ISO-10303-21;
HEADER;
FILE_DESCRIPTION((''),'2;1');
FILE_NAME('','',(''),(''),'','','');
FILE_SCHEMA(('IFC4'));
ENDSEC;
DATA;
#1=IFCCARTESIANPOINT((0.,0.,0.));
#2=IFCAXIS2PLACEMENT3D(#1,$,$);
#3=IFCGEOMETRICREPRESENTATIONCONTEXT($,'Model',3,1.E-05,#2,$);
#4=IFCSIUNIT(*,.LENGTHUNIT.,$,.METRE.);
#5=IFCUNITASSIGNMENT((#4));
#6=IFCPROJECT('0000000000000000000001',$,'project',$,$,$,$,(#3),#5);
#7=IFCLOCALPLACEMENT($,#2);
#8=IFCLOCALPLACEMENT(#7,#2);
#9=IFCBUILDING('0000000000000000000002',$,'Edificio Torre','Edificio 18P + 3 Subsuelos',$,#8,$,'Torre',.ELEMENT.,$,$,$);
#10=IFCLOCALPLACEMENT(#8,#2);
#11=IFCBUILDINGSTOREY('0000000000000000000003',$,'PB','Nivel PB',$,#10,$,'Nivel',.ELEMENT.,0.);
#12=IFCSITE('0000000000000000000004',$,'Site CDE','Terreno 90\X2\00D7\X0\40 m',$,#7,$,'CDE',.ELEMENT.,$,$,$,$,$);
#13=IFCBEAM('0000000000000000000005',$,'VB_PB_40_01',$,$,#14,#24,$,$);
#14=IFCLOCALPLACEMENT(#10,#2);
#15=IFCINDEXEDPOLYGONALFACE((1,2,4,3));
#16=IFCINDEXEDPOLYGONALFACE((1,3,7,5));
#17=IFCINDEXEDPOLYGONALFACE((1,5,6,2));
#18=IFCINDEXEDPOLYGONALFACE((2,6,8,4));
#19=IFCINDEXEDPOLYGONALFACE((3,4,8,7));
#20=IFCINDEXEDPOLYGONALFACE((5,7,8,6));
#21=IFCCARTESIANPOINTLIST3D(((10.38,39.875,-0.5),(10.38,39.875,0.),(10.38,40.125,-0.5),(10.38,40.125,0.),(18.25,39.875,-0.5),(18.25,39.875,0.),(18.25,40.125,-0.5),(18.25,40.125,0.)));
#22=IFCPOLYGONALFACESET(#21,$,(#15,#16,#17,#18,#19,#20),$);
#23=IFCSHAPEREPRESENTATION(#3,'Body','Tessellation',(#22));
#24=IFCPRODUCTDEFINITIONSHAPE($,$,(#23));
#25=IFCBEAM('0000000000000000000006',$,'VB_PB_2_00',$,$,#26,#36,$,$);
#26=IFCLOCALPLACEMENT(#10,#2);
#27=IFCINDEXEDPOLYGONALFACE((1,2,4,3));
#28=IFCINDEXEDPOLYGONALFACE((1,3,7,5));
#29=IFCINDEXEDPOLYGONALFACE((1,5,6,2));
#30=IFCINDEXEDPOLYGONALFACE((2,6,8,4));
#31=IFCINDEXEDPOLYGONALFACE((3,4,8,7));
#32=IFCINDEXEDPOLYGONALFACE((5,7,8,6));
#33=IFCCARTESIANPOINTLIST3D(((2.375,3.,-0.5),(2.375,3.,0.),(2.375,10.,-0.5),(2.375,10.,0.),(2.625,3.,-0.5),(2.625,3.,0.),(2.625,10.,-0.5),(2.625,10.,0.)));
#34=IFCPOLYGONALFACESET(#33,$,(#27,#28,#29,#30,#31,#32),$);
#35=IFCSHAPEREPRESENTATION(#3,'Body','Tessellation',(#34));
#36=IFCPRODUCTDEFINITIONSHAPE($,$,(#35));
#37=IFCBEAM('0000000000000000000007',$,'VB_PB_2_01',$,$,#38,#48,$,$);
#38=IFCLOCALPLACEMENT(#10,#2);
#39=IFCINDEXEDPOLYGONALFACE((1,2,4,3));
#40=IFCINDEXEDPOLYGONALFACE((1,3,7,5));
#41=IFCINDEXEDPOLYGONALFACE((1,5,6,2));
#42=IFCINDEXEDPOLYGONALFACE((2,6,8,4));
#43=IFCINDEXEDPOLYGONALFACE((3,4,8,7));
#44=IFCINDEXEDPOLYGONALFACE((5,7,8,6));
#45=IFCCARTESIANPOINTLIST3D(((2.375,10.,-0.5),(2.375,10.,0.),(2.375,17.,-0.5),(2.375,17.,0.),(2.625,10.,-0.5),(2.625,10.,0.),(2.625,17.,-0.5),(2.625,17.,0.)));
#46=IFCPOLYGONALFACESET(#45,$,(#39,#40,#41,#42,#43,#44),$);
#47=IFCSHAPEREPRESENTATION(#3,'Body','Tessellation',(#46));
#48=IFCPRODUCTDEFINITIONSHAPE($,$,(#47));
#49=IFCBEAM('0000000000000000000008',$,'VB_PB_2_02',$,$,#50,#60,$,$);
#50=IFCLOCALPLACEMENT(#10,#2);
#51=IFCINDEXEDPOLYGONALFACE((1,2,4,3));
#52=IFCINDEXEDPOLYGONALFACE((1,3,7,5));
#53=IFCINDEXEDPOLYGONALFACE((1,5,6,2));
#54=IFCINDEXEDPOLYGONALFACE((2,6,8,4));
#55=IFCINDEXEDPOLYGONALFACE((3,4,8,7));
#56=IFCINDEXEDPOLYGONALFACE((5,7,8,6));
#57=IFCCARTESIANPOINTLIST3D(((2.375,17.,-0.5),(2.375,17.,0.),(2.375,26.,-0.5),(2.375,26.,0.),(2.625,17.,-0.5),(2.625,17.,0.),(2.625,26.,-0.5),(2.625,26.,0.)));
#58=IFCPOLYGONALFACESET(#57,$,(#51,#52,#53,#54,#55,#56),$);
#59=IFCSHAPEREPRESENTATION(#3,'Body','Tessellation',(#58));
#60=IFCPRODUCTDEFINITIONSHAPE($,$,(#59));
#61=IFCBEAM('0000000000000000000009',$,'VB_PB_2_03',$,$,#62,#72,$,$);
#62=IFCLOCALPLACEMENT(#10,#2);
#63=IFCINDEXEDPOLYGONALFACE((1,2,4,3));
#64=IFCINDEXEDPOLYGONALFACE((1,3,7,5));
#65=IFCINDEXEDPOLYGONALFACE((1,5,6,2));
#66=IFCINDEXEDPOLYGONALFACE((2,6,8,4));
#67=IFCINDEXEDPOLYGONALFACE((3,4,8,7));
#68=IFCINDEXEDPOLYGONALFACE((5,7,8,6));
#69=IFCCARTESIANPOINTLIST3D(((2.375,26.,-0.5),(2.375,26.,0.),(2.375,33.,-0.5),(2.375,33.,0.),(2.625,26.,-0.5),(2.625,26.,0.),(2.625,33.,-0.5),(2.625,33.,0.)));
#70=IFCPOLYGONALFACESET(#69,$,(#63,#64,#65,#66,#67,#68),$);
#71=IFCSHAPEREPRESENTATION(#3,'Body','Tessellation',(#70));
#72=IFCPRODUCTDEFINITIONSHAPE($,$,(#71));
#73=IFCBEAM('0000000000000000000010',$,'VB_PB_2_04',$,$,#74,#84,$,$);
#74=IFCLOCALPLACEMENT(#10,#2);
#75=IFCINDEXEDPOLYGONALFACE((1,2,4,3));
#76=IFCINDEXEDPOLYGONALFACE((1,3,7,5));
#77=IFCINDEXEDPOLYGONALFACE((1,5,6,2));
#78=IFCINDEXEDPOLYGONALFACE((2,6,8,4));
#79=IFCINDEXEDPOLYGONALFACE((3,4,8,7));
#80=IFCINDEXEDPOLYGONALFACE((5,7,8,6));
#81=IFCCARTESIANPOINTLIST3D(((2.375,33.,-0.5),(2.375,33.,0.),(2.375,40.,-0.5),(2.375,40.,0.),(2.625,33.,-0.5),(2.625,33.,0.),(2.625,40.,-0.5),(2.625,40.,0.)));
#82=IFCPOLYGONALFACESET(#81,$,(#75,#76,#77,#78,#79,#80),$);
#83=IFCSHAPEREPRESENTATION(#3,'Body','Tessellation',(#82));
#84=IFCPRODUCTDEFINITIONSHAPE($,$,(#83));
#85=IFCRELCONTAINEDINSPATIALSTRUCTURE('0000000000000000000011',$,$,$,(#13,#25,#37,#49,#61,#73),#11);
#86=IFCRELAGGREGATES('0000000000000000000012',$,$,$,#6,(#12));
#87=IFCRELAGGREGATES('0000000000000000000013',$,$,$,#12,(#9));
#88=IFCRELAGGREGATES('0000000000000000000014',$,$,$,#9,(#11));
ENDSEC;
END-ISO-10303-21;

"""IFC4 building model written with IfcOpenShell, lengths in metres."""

from ifc_helpers import new_model, si_unit, frame, origin, origin_2d, place, context, project, spatial, rectangle, extrude, element, save


model = new_model("IFC4")

# Units and contexts
model_context = context("Model", 3, precision=1e-05, world=origin())
ifc_project = project(units=[si_unit("LENGTHUNIT", "METRE")], contexts=[model_context])

# Site, building, storey
site_placement = place(None, origin())
site = spatial("IfcSite", under=ifc_project, at=site_placement, Name="Site CDE", Description="Terreno 90×40 m", LongName="CDE", CompositionType="ELEMENT")
building_placement = place(site_placement, origin())
building = spatial("IfcBuilding", under=site, at=building_placement, Name="Edificio Torre", Description="Edificio 18P + 3 Subsuelos", LongName="Torre", CompositionType="ELEMENT")
storey_placement = place(building_placement, origin())
storey = spatial("IfcBuildingStorey", under=building, at=storey_placement, Name="PB", Description="Nivel PB", LongName="Nivel", CompositionType="ELEMENT", Elevation=0.0)

# Beams
beam_1_placement = place(storey_placement, frame((14.315, 40.0, -0.5)))
element("IfcBeam", 1, at=beam_1_placement, inside=storey, Name="VB_PB_40_01", context=model_context, shape_type="SweptSolid", body=[
    extrude(rectangle(XDim=7.87, YDim=0.25, at=origin_2d()), origin(), (0.0, 0.0, 1.0), 0.5),
])
for number, where, name in (
    (2, (2.5, 6.5, -0.5), "VB_PB_2_00"),
    (3, (2.5, 13.5, -0.5), "VB_PB_2_01"),
):
    element("IfcBeam", number, at=place(storey_placement, frame(where)), inside=storey, Name=name, context=model_context, shape_type="SweptSolid", body=[
        extrude(rectangle(XDim=0.25, YDim=7.0, at=origin_2d()), origin(), (0.0, 0.0, 1.0), 0.5),
    ])
beam_2_placement = place(storey_placement, frame((2.5, 21.5, -0.5)))
element("IfcBeam", 4, at=beam_2_placement, inside=storey, Name="VB_PB_2_02", context=model_context, shape_type="SweptSolid", body=[
    extrude(rectangle(XDim=0.25, YDim=9.0, at=origin_2d()), origin(), (0.0, 0.0, 1.0), 0.5),
])
for number, where, name in (
    (5, (2.5, 29.5, -0.5), "VB_PB_2_03"),
    (6, (2.5, 36.5, -0.5), "VB_PB_2_04"),
):
    element("IfcBeam", number, at=place(storey_placement, frame(where)), inside=storey, Name=name, context=model_context, shape_type="SweptSolid", body=[
        extrude(rectangle(XDim=0.25, YDim=7.0, at=origin_2d()), origin(), (0.0, 0.0, 1.0), 0.5),
    ])

save(model, "model.ifc")
